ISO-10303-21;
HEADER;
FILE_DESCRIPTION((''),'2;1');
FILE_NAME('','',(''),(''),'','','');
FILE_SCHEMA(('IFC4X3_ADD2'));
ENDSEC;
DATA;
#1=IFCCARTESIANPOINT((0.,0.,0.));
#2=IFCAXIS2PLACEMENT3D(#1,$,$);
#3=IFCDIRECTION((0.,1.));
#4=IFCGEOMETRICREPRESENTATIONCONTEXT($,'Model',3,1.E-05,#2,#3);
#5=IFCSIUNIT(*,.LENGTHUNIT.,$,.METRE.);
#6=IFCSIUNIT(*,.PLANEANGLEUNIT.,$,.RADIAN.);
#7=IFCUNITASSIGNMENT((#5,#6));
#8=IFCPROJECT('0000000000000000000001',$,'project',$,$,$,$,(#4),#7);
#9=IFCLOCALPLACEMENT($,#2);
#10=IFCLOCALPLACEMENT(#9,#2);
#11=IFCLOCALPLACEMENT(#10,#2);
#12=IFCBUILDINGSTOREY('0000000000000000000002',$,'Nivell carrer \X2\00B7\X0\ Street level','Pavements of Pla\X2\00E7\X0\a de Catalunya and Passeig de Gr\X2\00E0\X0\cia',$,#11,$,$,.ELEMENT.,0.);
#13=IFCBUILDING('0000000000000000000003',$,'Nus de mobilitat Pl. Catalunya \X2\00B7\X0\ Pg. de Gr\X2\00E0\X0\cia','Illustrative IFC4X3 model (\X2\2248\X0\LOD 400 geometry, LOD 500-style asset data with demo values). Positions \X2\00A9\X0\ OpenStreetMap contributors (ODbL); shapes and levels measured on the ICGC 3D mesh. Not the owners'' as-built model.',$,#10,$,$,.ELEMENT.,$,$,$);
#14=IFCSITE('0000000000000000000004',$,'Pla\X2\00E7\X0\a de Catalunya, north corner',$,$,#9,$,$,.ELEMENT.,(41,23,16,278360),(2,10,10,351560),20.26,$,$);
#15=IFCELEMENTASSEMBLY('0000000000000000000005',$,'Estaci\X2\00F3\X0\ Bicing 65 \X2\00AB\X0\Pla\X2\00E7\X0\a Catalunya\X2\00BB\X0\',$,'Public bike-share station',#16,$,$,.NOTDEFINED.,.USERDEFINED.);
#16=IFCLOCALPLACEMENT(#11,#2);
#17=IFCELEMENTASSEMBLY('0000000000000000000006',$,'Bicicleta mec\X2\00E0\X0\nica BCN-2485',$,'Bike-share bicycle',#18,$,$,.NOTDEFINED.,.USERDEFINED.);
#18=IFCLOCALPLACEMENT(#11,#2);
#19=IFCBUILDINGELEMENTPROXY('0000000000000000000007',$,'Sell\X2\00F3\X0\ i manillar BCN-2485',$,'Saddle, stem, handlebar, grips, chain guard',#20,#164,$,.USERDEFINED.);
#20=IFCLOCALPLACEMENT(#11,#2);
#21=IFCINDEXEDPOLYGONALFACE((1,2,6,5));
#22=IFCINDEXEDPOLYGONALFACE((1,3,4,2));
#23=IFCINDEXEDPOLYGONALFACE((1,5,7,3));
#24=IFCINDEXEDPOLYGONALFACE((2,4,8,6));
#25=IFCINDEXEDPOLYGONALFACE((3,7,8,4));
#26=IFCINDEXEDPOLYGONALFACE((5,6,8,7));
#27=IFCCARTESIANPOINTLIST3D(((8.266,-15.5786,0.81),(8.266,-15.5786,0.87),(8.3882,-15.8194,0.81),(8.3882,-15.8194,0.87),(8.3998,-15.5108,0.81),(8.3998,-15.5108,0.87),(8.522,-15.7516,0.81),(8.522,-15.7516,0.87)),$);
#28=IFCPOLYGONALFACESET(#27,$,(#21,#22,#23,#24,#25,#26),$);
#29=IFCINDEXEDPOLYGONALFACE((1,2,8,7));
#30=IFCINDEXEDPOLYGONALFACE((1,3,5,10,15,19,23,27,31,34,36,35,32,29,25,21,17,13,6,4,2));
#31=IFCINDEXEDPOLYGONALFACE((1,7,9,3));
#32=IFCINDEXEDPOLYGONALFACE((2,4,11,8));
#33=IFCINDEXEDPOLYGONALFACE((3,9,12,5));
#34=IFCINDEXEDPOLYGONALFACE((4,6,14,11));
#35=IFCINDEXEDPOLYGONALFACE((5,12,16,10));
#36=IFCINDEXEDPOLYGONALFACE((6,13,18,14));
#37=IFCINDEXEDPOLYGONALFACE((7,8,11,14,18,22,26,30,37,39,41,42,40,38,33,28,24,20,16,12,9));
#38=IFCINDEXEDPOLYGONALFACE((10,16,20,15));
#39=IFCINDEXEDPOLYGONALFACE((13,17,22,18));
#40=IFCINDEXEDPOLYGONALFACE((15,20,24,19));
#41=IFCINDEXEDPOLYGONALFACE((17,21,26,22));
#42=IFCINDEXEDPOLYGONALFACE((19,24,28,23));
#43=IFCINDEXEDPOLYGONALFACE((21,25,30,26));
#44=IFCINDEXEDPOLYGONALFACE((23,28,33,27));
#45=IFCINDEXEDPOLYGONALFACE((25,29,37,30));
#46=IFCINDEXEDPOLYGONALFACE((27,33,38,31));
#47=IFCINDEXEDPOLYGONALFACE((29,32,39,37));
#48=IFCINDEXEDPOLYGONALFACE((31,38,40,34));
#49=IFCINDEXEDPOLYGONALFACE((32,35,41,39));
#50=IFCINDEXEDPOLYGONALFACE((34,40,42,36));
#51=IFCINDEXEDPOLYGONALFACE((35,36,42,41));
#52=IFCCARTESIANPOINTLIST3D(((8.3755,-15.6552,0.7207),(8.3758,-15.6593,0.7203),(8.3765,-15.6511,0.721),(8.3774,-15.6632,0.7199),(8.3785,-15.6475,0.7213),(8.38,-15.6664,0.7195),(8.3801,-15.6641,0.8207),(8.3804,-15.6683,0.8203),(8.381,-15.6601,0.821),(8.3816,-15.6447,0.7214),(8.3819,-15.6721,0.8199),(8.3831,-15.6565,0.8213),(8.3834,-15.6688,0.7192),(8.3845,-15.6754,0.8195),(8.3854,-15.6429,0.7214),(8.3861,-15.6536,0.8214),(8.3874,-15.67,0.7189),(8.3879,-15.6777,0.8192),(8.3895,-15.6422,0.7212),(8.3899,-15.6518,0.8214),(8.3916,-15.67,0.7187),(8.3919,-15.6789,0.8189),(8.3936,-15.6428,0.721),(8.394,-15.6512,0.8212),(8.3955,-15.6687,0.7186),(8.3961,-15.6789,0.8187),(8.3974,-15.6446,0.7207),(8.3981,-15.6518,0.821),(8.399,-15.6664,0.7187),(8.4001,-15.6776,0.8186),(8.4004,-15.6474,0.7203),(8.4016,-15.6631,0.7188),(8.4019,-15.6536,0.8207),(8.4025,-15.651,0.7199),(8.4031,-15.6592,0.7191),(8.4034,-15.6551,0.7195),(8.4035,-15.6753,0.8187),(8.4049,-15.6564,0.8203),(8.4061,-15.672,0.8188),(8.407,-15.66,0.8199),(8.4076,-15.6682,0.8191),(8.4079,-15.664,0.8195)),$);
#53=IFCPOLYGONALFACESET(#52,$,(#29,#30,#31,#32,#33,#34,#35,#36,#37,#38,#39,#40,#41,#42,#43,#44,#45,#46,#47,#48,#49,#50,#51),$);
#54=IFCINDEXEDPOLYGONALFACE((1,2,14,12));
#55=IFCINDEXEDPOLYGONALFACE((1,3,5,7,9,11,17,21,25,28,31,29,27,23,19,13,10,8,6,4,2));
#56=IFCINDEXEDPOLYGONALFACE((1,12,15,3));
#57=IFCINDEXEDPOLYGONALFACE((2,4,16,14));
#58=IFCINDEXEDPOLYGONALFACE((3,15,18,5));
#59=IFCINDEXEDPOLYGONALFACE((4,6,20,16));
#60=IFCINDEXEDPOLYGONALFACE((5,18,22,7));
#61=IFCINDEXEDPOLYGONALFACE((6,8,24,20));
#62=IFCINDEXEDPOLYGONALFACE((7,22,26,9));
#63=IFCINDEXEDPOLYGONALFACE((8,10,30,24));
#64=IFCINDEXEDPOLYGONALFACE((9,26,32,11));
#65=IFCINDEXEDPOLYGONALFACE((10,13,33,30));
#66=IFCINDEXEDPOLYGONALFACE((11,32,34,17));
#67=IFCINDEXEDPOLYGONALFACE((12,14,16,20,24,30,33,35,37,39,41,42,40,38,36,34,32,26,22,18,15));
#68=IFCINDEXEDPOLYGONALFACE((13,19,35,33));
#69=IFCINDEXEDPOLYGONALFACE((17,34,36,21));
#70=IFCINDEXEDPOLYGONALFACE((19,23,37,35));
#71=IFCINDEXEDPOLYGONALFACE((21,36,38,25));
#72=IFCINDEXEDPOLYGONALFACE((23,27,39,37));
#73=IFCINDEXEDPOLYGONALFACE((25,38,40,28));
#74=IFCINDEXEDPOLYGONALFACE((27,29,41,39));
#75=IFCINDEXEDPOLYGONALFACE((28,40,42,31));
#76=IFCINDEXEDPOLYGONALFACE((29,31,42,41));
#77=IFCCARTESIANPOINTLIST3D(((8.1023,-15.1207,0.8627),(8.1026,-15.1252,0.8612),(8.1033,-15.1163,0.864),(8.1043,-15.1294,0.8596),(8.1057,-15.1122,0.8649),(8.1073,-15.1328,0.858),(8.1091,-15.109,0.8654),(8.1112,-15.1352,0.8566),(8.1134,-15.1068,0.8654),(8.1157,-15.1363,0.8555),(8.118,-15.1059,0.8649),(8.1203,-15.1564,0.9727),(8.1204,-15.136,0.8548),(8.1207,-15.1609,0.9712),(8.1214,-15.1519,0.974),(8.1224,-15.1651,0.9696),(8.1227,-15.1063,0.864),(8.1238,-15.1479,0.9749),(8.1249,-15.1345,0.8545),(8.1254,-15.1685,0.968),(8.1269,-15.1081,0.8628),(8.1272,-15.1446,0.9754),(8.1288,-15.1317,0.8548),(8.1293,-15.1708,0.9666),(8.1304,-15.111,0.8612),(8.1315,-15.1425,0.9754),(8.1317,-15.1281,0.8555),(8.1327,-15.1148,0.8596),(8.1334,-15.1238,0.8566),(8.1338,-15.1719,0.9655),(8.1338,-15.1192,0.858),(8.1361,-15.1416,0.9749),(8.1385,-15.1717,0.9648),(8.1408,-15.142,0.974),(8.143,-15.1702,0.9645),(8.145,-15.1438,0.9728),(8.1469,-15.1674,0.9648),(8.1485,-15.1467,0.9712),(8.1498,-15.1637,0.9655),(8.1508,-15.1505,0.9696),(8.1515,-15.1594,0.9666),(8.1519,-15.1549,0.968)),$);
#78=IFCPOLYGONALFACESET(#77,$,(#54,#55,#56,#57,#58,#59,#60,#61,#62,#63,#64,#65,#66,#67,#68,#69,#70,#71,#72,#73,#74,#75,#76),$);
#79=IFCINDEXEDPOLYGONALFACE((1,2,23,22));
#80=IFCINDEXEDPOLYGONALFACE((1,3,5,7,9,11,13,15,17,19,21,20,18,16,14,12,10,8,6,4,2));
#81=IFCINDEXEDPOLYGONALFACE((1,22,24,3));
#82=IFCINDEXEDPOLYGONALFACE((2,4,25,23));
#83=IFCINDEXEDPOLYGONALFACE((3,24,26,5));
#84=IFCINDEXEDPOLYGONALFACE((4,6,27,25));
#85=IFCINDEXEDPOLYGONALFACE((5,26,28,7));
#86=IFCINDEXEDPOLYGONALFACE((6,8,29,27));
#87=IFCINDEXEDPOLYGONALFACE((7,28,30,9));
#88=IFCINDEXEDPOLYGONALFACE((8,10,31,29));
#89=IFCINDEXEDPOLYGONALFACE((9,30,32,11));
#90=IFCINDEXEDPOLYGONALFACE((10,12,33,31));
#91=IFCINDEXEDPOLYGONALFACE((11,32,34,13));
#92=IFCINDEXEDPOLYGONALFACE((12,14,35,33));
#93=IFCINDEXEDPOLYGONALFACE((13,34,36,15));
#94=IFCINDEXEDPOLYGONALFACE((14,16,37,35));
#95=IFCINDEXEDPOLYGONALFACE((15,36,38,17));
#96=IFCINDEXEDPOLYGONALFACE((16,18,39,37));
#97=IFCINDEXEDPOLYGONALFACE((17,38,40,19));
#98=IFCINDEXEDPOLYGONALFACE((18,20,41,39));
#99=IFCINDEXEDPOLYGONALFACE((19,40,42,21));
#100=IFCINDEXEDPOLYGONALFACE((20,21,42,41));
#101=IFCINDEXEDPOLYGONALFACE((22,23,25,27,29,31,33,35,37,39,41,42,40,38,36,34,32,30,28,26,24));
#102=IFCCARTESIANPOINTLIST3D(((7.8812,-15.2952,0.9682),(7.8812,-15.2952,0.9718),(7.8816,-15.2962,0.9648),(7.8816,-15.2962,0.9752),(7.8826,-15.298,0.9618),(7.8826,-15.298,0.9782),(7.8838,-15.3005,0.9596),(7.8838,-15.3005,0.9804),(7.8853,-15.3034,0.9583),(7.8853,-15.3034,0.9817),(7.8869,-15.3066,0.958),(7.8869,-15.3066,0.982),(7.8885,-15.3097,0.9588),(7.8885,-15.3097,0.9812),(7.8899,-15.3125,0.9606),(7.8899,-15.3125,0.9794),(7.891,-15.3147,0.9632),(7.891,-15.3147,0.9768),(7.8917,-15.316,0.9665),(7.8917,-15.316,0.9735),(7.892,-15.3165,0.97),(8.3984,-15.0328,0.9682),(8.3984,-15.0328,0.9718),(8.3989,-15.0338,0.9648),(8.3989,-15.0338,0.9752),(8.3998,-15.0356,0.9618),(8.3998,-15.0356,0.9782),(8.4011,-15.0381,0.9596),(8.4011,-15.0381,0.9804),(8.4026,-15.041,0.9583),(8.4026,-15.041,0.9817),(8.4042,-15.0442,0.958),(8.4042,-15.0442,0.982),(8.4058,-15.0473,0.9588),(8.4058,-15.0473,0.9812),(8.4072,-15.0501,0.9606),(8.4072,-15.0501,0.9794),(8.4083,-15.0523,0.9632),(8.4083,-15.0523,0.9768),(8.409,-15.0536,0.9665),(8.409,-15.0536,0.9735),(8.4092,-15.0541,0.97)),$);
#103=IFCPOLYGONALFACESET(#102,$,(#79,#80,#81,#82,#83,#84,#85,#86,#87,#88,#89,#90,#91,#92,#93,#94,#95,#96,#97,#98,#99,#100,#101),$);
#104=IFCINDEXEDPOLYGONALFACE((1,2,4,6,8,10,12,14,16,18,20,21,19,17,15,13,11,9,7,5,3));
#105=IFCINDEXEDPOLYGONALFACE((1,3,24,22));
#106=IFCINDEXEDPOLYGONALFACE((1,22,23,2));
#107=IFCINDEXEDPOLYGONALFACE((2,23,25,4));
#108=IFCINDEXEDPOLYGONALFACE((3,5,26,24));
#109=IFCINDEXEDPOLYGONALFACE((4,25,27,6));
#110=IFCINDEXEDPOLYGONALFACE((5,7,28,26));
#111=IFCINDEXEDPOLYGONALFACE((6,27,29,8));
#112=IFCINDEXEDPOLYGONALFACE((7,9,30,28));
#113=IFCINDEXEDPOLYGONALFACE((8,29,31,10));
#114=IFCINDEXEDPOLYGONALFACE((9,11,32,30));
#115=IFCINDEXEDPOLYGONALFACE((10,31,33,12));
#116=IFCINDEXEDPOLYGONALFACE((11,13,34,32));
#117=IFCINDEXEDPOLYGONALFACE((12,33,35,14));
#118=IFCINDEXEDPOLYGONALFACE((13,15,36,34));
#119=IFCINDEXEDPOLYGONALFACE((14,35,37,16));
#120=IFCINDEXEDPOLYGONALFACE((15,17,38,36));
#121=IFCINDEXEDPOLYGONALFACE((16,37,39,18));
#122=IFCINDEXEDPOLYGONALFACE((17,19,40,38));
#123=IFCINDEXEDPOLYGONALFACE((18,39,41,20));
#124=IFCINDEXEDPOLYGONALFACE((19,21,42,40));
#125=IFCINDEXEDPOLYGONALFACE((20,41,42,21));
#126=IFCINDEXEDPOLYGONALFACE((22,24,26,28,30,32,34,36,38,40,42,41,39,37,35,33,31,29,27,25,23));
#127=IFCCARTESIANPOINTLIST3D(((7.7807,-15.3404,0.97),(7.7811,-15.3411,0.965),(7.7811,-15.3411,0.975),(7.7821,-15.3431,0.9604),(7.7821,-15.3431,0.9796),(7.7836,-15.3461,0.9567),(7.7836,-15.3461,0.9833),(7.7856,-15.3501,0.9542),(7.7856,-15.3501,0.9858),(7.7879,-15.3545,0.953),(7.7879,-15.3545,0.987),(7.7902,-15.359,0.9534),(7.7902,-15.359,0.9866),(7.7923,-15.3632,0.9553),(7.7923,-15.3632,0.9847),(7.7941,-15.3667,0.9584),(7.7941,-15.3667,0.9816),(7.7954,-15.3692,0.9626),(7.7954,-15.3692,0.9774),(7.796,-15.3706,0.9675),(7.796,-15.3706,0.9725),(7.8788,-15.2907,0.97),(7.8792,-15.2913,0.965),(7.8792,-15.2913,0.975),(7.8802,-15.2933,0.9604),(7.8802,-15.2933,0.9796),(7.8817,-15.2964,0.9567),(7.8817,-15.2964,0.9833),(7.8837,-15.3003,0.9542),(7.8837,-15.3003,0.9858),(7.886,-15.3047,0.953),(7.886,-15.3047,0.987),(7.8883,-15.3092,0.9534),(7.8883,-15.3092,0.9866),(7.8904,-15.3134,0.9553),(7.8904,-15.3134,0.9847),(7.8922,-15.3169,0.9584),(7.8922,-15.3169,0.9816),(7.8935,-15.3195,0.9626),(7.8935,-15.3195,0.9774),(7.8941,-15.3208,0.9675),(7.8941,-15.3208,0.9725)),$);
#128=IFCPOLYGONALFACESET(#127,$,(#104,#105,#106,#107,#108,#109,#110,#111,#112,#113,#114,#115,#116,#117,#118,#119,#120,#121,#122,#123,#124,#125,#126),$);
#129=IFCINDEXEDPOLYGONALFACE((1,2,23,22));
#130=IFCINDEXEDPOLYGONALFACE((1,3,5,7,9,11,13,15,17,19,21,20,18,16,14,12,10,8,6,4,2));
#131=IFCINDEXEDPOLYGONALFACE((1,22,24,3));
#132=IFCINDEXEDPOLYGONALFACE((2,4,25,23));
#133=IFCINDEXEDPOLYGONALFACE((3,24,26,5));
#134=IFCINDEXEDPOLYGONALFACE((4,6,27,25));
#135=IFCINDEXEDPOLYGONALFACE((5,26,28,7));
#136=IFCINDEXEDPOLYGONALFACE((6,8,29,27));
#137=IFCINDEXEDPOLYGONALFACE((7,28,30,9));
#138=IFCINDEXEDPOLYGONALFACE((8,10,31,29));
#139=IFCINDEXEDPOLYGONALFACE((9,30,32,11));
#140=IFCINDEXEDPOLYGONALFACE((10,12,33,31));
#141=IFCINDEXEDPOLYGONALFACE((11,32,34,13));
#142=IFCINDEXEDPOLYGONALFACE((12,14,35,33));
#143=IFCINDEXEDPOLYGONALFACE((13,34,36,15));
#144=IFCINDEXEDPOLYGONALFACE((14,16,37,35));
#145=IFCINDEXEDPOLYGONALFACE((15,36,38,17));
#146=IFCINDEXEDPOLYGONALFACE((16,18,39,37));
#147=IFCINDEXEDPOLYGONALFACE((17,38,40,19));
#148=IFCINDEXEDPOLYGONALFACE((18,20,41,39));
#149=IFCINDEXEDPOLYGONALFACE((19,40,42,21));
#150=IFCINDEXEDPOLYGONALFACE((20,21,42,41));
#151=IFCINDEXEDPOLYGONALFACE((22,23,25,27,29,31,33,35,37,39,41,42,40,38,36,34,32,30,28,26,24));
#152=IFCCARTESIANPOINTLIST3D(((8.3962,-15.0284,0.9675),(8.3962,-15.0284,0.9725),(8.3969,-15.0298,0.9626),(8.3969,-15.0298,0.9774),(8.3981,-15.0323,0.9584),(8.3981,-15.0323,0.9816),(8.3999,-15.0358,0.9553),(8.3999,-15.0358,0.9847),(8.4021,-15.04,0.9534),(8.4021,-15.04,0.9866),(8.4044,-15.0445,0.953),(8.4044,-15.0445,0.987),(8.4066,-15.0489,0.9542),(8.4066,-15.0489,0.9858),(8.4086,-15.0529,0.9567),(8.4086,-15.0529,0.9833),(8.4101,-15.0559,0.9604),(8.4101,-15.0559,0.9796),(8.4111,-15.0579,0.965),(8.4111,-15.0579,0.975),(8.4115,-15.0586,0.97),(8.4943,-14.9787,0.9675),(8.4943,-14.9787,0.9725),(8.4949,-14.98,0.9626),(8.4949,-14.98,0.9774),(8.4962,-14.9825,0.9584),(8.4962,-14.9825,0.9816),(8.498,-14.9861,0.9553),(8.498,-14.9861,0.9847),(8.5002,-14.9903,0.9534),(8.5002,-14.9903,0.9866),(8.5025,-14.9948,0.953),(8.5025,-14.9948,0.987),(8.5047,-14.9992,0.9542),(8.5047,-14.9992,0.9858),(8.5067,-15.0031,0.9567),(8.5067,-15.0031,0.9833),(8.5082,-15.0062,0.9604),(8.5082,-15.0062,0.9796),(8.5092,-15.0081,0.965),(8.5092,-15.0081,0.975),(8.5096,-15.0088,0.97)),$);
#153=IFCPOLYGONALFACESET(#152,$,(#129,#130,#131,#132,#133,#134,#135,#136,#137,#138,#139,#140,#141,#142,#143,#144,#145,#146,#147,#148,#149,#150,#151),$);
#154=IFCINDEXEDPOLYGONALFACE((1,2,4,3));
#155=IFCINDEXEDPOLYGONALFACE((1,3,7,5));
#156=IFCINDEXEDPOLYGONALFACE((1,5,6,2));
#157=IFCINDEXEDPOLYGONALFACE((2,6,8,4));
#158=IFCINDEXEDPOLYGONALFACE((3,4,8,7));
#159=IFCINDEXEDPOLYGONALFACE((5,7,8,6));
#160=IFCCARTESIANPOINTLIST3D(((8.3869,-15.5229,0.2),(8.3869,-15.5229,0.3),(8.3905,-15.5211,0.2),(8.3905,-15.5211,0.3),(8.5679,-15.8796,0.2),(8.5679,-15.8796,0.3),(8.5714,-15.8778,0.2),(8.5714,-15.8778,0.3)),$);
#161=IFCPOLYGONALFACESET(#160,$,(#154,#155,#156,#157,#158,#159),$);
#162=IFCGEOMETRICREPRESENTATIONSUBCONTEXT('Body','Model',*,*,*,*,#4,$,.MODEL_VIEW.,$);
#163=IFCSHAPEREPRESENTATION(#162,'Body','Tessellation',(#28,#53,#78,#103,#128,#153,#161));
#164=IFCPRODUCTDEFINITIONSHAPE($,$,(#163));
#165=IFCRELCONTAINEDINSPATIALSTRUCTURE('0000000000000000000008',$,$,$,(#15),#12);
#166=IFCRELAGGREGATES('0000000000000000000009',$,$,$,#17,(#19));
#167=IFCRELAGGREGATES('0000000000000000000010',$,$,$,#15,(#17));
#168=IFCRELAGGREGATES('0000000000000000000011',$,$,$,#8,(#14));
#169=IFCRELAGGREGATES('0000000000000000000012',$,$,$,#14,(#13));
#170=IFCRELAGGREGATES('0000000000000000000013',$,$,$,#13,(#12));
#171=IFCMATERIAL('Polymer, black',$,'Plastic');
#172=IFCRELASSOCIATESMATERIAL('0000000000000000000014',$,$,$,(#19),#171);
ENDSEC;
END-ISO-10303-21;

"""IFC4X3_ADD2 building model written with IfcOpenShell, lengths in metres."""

from ifc_helpers import new_model, si_unit, direction, frame, origin, origin_2d_with_axis, place, context, subcontext, project, spatial, rectangle, circle, extrude, material, element, aggregate, save


model = new_model("IFC4X3_ADD2")

# Units and contexts
model_context = context("Model", 3, precision=1e-05, world=origin(), true_north=direction((0.0, 1.0)))
body_context = subcontext(model_context, "Body", "Model", "MODEL_VIEW")
ifc_project = project(units=[si_unit("LENGTHUNIT", "METRE"), si_unit("PLANEANGLEUNIT", "RADIAN")], contexts=[model_context])

# Site, building, storey
site_placement = place(None, origin())
site = spatial("IfcSite", under=ifc_project, at=site_placement, Name="Plaça de Catalunya, north corner", CompositionType="ELEMENT", RefLatitude=(41, 23, 16, 278360), RefLongitude=(2, 10, 10, 351560), RefElevation=20.26)
building_placement = place(site_placement, origin())
building = spatial("IfcBuilding", under=site, at=building_placement, Name="Nus de mobilitat Pl. Catalunya · Pg. de Gràcia", Description="Illustrative IFC4X3 model (≈LOD 400 geometry, LOD 500-style asset data with demo values). Positions © OpenStreetMap contributors (ODbL); shapes and levels measured on the ICGC 3D mesh. Not the owners' as-built model.", CompositionType="ELEMENT")
storey_placement = place(building_placement, origin())
storey = spatial("IfcBuildingStorey", under=building, at=storey_placement, Name="Nivell carrer · Street level", Description="Pavements of Plaça de Catalunya and Passeig de Gràcia", CompositionType="ELEMENT", Elevation=0.0)

# Element assemblies, building element proxy
assembly_1_placement = place(building_placement, origin())
assembly_1 = element("IfcElementAssembly", 1, at=assembly_1_placement, inside=storey, Name="Estació Bicing 65 «Plaça Catalunya»", ObjectType="Public bike-share station", AssemblyPlace="NOTDEFINED", PredefinedType="USERDEFINED")
assembly_2_placement = place(building_placement, origin())
assembly_2 = element("IfcElementAssembly", 2, at=assembly_2_placement, Name="Bicicleta mecànica BCN-2485", ObjectType="Bike-share bicycle", AssemblyPlace="NOTDEFINED", PredefinedType="USERDEFINED")
ifc_material_1 = material(Name="Polymer, black", Category="Plastic")
proxy_1_placement = place(building_placement, origin())
proxy_1 = element("IfcBuildingElementProxy", 3, at=proxy_1_placement, material=ifc_material_1, Name="Selló i manillar BCN-2485", ObjectType="Saddle, stem, handlebar, grips, chain guard", PredefinedType="USERDEFINED", context=body_context, shape_type="SweptSolid", body=[
    extrude(rectangle(XDim=0.27, YDim=0.15, at=origin_2d_with_axis()), frame((8.394, -15.6651, 0.87), z_axis=(0.0, 0.0, -1.0), x_axis=(-0.452435, 0.891798, 0.0)), (0.0, 0.0, 1.0), 0.06),
    extrude(circle(Radius=0.014, at=origin_2d_with_axis()), frame((8.3895, -15.6562, 0.72), z_axis=(0.045019, -0.088737, 0.995037), x_axis=(0.0, 0.996047, 0.088827)), (0.0, 0.0, 1.0), 0.1005),
    extrude(circle(Radius=0.016, at=origin_2d_with_axis()), frame((8.118, -15.1211, 0.86), z_axis=(0.154616, -0.304766, 0.939793), x_axis=(0.0, 0.951232, 0.308475)), (0.0, 0.0, 1.0), 0.117),
    extrude(circle(Radius=0.012, at=origin_2d_with_axis()), frame((7.8865, -15.3058, 0.97), z_axis=(0.891798, 0.452435, 0.0), x_axis=(0.452435, -0.891798, 0.0)), (0.0, 0.0, 1.0), 0.58),
    extrude(circle(Radius=0.017, at=origin_2d_with_axis()), frame((7.8865, -15.3058, 0.97), z_axis=(-0.891798, -0.452435, 0.0), x_axis=(-0.452435, 0.891798, 0.0)), (0.0, 0.0, 1.0), 0.11),
    extrude(circle(Radius=0.017, at=origin_2d_with_axis()), frame((8.4038, -15.0434, 0.97), z_axis=(0.891798, 0.452435, 0.0), x_axis=(0.452435, -0.891798, 0.0)), (0.0, 0.0, 1.0), 0.11),
    extrude(rectangle(XDim=0.4, YDim=0.1, at=origin_2d_with_axis()), frame((8.4774, -15.7013, 0.25), z_axis=(0.891798, 0.452435, 0.0), x_axis=(-0.452435, 0.891798, 0.0)), (0.0, 0.0, 1.0), 0.004),
])
aggregate(assembly_2, [proxy_1])
aggregate(assembly_1, [assembly_2])

save(model, "model.ifc")
